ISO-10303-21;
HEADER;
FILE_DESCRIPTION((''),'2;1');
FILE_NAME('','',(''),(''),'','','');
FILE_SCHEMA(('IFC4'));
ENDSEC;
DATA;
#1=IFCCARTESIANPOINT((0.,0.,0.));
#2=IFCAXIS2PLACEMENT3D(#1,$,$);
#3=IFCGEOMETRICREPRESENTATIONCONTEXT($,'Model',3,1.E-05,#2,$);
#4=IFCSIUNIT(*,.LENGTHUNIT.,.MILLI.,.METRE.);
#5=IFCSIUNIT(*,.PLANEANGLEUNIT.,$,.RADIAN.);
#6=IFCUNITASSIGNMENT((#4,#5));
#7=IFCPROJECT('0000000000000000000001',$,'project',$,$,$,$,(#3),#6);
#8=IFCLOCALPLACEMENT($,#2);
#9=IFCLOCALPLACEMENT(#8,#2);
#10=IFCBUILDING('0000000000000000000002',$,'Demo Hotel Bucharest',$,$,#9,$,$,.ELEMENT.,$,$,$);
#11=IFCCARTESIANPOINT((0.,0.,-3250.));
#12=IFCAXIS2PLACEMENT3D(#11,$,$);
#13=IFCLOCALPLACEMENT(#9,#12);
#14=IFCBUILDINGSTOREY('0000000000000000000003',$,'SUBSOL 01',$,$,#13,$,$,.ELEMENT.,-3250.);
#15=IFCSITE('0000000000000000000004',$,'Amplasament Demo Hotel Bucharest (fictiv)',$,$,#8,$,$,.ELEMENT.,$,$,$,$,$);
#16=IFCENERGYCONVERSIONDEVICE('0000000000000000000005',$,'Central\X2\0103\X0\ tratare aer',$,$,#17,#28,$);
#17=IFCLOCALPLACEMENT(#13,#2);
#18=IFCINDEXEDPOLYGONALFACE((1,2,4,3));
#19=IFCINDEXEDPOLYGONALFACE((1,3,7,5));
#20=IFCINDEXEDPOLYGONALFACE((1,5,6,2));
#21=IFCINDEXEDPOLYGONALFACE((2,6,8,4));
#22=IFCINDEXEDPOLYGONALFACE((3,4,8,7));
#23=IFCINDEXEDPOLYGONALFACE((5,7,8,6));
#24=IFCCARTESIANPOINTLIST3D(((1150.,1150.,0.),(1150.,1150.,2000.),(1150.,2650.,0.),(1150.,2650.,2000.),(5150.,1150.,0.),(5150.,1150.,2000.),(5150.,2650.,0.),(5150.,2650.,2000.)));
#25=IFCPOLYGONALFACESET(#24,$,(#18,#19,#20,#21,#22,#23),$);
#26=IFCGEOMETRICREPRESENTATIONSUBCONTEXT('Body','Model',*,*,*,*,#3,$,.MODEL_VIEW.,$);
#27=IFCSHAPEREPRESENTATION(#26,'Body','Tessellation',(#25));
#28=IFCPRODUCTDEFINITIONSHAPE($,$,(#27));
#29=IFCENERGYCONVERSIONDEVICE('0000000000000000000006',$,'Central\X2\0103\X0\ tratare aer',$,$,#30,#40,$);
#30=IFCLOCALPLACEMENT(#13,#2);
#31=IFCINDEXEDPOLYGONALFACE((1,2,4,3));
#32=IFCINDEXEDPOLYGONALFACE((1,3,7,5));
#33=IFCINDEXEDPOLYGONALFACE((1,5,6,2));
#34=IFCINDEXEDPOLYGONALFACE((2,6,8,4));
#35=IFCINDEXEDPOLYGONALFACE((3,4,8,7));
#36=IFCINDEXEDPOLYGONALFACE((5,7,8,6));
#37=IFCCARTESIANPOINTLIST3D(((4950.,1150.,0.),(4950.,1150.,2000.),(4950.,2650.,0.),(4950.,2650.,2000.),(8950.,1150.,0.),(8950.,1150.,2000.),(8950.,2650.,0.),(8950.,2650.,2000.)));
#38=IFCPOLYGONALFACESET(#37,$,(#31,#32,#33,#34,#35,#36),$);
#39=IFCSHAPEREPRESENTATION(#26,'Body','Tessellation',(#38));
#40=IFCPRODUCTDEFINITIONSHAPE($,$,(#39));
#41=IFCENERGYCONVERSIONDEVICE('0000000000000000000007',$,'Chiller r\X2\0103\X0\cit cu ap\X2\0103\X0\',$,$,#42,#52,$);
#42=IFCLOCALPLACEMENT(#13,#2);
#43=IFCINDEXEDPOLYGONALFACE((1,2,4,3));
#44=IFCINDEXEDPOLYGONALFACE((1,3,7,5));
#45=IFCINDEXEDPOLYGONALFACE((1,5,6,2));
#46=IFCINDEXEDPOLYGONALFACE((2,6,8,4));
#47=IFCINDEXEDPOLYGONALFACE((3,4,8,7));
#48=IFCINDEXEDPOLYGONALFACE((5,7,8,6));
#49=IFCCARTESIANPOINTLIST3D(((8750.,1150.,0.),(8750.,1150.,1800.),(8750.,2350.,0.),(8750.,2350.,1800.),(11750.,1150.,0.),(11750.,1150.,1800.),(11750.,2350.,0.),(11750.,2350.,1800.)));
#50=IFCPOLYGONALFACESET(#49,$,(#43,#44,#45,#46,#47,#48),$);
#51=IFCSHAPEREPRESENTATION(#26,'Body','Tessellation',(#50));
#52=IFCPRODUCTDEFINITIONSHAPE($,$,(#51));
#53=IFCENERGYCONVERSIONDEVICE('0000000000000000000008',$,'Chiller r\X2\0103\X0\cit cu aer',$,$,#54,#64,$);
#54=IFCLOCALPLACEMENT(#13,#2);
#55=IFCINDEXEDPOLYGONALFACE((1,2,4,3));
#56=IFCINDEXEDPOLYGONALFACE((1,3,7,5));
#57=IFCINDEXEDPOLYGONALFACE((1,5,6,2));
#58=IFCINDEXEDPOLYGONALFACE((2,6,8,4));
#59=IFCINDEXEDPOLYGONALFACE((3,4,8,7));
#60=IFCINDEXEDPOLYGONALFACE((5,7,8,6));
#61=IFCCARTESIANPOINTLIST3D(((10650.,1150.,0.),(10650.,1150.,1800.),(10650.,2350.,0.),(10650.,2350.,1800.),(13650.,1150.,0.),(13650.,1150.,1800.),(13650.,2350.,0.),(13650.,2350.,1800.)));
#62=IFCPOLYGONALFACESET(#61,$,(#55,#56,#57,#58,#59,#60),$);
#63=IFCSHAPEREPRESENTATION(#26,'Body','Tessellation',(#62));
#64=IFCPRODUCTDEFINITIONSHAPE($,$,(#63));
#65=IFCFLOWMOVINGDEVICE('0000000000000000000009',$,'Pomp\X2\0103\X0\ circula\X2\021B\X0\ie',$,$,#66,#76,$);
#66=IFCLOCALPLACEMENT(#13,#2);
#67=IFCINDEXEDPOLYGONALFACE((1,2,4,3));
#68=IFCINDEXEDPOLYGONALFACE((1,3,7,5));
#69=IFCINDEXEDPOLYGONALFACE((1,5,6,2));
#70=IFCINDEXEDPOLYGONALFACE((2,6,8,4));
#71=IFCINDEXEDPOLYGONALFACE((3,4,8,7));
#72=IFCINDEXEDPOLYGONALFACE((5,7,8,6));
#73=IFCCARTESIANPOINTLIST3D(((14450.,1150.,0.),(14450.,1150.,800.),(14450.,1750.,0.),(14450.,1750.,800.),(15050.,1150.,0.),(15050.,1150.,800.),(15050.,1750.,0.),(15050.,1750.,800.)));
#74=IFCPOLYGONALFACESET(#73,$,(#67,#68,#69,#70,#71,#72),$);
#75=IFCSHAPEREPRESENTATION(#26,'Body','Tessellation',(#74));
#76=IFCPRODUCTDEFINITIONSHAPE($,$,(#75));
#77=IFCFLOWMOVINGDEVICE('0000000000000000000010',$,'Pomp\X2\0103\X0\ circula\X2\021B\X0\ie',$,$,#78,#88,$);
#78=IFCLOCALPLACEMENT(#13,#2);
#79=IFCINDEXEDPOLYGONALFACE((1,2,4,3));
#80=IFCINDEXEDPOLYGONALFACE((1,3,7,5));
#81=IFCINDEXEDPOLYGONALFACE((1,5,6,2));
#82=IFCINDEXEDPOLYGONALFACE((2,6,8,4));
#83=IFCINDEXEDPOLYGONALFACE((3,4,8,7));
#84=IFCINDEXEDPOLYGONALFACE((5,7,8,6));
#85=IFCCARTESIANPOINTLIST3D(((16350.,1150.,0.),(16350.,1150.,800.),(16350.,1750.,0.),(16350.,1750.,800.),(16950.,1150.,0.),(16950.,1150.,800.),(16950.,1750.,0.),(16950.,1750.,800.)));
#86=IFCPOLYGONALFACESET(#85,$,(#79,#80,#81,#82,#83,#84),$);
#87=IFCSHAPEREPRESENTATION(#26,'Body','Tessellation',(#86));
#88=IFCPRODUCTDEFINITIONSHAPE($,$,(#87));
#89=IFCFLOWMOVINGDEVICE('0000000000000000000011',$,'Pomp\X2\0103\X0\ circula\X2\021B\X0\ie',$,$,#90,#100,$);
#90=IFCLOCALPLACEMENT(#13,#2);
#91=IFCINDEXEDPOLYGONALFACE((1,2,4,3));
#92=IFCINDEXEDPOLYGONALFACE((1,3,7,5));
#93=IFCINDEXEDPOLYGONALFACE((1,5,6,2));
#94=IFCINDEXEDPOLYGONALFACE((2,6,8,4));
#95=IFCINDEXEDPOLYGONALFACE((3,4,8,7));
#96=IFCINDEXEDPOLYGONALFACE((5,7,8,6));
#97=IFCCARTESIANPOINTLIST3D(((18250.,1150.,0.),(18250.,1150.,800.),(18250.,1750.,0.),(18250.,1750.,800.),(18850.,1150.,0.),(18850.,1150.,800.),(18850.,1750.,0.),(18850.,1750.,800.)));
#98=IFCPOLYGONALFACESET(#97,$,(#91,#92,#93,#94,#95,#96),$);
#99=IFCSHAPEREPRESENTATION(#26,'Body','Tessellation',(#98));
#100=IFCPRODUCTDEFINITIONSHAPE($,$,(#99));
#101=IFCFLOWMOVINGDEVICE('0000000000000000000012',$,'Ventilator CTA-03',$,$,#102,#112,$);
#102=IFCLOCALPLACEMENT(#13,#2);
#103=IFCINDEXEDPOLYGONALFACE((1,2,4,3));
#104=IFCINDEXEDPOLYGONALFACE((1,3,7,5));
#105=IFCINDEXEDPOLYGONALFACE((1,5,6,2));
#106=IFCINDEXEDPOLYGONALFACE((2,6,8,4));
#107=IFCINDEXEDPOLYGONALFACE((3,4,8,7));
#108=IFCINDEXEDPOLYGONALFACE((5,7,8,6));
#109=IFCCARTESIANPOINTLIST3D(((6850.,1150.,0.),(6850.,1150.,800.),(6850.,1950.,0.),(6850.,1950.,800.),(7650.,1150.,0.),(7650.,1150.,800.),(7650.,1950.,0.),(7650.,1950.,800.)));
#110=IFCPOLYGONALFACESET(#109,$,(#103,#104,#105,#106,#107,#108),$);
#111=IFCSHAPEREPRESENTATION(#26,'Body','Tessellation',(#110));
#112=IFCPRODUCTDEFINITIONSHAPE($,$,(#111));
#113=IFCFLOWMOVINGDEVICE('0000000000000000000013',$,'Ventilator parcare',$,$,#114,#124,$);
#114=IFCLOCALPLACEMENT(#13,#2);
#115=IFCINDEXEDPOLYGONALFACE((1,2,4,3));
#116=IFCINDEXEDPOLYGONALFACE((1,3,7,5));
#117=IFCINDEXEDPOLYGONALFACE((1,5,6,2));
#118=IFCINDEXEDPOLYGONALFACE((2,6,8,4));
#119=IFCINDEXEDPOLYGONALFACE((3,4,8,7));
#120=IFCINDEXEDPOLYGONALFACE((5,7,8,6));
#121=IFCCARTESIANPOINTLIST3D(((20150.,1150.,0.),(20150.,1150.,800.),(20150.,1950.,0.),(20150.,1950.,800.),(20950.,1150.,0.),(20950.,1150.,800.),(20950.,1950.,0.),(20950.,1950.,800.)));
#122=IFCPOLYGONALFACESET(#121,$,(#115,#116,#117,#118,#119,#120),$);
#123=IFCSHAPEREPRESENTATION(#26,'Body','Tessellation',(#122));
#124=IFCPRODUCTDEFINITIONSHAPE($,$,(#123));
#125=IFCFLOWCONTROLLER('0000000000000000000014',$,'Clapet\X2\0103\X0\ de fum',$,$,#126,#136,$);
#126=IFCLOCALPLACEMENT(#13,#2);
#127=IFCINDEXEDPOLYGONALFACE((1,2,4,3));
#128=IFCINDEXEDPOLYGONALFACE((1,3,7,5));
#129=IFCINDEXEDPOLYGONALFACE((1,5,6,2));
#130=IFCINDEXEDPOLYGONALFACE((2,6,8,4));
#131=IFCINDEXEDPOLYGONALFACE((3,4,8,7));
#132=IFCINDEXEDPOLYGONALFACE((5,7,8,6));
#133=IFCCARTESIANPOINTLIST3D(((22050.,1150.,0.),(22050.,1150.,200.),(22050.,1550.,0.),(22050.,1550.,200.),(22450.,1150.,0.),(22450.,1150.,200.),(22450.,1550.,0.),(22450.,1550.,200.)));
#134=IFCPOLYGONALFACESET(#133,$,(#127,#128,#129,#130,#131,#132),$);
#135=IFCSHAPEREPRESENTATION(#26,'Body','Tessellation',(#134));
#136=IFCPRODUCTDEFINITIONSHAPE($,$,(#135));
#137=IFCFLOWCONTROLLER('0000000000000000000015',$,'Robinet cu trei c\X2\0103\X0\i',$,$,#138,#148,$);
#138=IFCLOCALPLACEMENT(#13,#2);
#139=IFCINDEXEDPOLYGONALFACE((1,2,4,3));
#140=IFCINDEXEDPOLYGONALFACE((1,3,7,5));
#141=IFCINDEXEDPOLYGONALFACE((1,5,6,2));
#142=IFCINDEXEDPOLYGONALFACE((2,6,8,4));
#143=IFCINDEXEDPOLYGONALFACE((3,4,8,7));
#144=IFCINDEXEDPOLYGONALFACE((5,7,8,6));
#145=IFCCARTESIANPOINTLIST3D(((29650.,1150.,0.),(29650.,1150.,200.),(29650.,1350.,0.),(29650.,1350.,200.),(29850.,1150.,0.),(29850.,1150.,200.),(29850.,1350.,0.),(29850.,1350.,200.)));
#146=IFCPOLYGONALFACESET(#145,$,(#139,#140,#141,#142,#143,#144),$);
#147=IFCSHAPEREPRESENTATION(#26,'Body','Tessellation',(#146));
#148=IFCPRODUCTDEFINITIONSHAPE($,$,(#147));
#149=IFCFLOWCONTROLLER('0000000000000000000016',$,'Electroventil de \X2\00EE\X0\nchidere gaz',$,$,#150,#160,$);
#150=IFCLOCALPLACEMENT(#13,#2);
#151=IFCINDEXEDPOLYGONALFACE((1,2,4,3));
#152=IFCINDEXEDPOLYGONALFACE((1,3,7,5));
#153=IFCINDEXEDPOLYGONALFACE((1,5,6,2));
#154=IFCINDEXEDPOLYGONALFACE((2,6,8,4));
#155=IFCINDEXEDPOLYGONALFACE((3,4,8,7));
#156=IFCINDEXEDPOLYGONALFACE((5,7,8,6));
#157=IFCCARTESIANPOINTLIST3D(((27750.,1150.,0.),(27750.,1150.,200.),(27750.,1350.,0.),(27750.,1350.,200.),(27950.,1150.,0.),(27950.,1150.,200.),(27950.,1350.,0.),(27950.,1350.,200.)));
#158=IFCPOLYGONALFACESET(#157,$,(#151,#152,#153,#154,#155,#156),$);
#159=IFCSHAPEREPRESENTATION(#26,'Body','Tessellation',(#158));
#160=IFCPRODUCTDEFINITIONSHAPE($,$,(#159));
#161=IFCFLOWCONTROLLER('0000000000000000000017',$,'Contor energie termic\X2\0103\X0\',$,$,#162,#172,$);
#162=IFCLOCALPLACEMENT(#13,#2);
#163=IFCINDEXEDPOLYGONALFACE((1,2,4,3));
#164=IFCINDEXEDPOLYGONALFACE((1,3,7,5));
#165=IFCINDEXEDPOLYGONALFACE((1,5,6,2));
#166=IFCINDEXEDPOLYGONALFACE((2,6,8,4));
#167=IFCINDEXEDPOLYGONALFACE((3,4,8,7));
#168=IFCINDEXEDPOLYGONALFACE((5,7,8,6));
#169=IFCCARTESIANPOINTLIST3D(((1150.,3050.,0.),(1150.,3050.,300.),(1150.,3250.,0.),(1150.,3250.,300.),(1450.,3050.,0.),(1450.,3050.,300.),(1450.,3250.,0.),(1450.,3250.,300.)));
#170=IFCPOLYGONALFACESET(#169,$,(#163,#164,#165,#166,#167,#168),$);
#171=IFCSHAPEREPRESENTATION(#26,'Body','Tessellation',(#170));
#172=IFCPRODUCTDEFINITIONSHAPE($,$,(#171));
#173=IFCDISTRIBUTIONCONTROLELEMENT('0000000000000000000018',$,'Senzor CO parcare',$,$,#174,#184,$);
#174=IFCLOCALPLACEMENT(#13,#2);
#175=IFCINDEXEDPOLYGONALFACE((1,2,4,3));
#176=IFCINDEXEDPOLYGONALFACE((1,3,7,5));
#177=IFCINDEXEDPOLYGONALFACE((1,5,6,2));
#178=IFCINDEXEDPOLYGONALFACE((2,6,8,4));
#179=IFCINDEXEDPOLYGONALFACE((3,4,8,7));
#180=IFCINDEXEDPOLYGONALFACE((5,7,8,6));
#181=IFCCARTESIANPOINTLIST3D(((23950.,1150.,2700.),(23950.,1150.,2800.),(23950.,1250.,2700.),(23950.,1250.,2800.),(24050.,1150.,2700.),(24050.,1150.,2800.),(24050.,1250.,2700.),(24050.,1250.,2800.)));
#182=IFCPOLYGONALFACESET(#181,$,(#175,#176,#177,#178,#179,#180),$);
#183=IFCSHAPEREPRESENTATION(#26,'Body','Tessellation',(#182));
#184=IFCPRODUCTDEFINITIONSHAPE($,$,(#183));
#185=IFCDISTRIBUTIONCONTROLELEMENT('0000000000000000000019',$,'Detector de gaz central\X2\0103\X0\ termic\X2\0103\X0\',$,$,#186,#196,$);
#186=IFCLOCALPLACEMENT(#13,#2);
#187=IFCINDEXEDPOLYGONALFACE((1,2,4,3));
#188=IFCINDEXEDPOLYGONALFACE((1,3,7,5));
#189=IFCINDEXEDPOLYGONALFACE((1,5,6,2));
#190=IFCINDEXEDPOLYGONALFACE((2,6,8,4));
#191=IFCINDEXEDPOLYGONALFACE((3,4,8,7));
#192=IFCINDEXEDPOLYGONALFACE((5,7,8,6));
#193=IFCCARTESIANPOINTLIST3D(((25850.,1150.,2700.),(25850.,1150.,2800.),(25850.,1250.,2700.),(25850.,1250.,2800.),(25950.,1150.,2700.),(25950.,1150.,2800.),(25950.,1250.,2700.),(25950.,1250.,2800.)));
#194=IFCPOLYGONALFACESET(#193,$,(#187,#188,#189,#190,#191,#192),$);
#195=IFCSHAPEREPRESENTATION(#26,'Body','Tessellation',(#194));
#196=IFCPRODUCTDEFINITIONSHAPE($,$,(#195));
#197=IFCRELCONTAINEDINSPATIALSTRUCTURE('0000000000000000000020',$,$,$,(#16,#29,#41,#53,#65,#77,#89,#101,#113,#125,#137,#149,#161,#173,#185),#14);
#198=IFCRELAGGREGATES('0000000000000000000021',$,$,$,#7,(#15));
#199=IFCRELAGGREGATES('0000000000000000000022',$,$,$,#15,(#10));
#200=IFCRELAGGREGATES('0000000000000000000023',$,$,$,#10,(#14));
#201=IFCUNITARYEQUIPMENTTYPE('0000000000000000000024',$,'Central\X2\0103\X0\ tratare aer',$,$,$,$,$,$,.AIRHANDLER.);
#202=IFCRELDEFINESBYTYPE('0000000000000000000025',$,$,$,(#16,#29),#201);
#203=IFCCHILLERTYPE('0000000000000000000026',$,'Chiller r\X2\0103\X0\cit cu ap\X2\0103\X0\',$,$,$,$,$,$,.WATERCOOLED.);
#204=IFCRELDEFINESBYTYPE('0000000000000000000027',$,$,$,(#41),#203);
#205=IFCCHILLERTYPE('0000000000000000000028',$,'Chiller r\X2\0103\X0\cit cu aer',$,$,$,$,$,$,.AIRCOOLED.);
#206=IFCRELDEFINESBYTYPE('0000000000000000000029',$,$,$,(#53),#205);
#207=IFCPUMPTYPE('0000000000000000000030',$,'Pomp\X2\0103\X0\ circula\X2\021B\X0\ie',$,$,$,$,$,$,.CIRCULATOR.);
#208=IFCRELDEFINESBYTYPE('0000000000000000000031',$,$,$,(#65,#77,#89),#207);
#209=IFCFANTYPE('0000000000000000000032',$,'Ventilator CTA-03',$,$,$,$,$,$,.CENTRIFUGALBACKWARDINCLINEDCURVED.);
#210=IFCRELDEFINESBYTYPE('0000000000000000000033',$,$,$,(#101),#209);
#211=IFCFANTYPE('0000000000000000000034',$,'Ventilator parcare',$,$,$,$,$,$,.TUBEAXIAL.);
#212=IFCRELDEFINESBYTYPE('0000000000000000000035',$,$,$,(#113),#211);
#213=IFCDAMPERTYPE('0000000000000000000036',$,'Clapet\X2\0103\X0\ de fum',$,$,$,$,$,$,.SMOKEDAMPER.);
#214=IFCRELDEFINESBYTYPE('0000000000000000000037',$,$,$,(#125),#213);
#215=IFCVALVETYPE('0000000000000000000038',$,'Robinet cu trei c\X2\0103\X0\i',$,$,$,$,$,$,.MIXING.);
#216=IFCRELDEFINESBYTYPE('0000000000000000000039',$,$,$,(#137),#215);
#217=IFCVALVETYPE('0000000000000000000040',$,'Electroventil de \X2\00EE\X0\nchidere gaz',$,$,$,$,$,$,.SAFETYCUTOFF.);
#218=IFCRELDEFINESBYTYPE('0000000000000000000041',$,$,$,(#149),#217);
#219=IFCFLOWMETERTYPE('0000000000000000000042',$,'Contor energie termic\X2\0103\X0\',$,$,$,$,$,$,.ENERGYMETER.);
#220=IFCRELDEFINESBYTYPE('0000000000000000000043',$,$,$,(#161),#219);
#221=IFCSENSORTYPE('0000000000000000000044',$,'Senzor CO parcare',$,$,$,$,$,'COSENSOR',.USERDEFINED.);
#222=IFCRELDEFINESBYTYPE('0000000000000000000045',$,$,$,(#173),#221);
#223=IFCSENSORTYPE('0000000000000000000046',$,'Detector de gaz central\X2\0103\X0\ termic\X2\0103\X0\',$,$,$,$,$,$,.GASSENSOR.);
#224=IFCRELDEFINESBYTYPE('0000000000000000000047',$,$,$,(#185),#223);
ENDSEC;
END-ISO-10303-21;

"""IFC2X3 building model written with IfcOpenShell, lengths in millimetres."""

from ifc_helpers import new_model, si_unit, frame, frame_2d, origin, place, context, subcontext, project, spatial, rectangle, extrude, type_object, element, save


model = new_model("IFC2X3")

# Units and contexts
model_context = context("Model", 3, precision=1e-05, world=origin())
body_context = subcontext(model_context, "Body", "Model", "MODEL_VIEW")
ifc_project = project(units=[si_unit("LENGTHUNIT", "METRE", prefix="MILLI"), si_unit("PLANEANGLEUNIT", "RADIAN")], contexts=[model_context])

# Site, building, storey
site_placement = place(None, origin())
site = spatial("IfcSite", under=ifc_project, at=site_placement, Name="Amplasament Demo Hotel Bucharest (fictiv)", CompositionType="ELEMENT")
building_placement = place(site_placement, origin())
building = spatial("IfcBuilding", under=site, at=building_placement, Name="Demo Hotel Bucharest", CompositionType="ELEMENT")
storey_placement = place(building_placement, frame((0.0, 0.0, -3250.0)))
storey = spatial("IfcBuildingStorey", under=building, at=storey_placement, Name="SUBSOL 01", CompositionType="ELEMENT", Elevation=-3250.0)

# Energy conversion devices
unitary_equipment_type = type_object("IfcUnitaryEquipmentType", Name="Centrală tratare aer", PredefinedType="AIRHANDLER")
for number, where, name in (
    (1, (1150.0, 1150.0, 0.0), "Centrală tratare aer"),
    (2, (4950.0, 1150.0, 0.0), "Centrală tratare aer"),
):
    element("IfcEnergyConversionDevice", number, at=place(storey_placement, frame(where)), inside=storey, type_object=unitary_equipment_type, Name=name, context=body_context, shape_type="SweptSolid", body=[
        extrude(rectangle(XDim=4000.0, YDim=1500.0, at=frame_2d((2000.0, 750.0))), origin(), (0.0, 0.0, 1.0), 2000.0),
    ])
chiller_type_1 = type_object("IfcChillerType", Name="Chiller răcit cu apă", PredefinedType="WATERCOOLED")
energy_conversion_device_1_placement = place(storey_placement, frame((8750.0, 1150.0, 0.0)))
element("IfcEnergyConversionDevice", 3, at=energy_conversion_device_1_placement, inside=storey, type_object=chiller_type_1, Name="Chiller răcit cu apă", context=body_context, shape_type="SweptSolid", body=[
    extrude(rectangle(XDim=3000.0, YDim=1200.0, at=frame_2d((1500.0, 600.0))), origin(), (0.0, 0.0, 1.0), 1800.0),
])
chiller_type_2 = type_object("IfcChillerType", Name="Chiller răcit cu aer", PredefinedType="AIRCOOLED")
energy_conversion_device_2_placement = place(storey_placement, frame((10650.0, 1150.0, 0.0)))
element("IfcEnergyConversionDevice", 4, at=energy_conversion_device_2_placement, inside=storey, type_object=chiller_type_2, Name="Chiller răcit cu aer", context=body_context, shape_type="SweptSolid", body=[
    extrude(rectangle(XDim=3000.0, YDim=1200.0, at=frame_2d((1500.0, 600.0))), origin(), (0.0, 0.0, 1.0), 1800.0),
])

# Flow moving devices
pump_type = type_object("IfcPumpType", Name="Pompă circulație", PredefinedType="CIRCULATOR")
for number, where, name in (
    (5, (14450.0, 1150.0, 0.0), "Pompă circulație"),
    (6, (16350.0, 1150.0, 0.0), "Pompă circulație"),
    (7, (18250.0, 1150.0, 0.0), "Pompă circulație"),
):
    element("IfcFlowMovingDevice", number, at=place(storey_placement, frame(where)), inside=storey, type_object=pump_type, Name=name, context=body_context, shape_type="SweptSolid", body=[
        extrude(rectangle(XDim=600.0, YDim=600.0, at=frame_2d((300.0, 300.0))), origin(), (0.0, 0.0, 1.0), 800.0),
    ])
fan_type_1 = type_object("IfcFanType", Name="Ventilator CTA-03", PredefinedType="CENTRIFUGALBACKWARDINCLINEDCURVED")
flow_moving_device_1_placement = place(storey_placement, frame((6850.0, 1150.0, 0.0)))
element("IfcFlowMovingDevice", 8, at=flow_moving_device_1_placement, inside=storey, type_object=fan_type_1, Name="Ventilator CTA-03", context=body_context, shape_type="SweptSolid", body=[
    extrude(rectangle(XDim=800.0, YDim=800.0, at=frame_2d((400.0, 400.0))), origin(), (0.0, 0.0, 1.0), 800.0),
])
fan_type_2 = type_object("IfcFanType", Name="Ventilator parcare", PredefinedType="TUBEAXIAL")
flow_moving_device_2_placement = place(storey_placement, frame((20150.0, 1150.0, 0.0)))
element("IfcFlowMovingDevice", 9, at=flow_moving_device_2_placement, inside=storey, type_object=fan_type_2, Name="Ventilator parcare", context=body_context, shape_type="SweptSolid", body=[
    extrude(rectangle(XDim=800.0, YDim=800.0, at=frame_2d((400.0, 400.0))), origin(), (0.0, 0.0, 1.0), 800.0),
])

# Flow controllers
damper_type = type_object("IfcDamperType", Name="Clapetă de fum", PredefinedType="SMOKEDAMPER")
flow_controller_1_placement = place(storey_placement, frame((22050.0, 1150.0, 0.0)))
element("IfcFlowController", 10, at=flow_controller_1_placement, inside=storey, type_object=damper_type, Name="Clapetă de fum", context=body_context, shape_type="SweptSolid", body=[
    extrude(rectangle(XDim=400.0, YDim=400.0, at=frame_2d((200.0, 200.0))), origin(), (0.0, 0.0, 1.0), 200.0),
])
valve_type_1 = type_object("IfcValveType", Name="Robinet cu trei căi", PredefinedType="MIXING")
flow_controller_2_placement = place(storey_placement, frame((29650.0, 1150.0, 0.0)))
element("IfcFlowController", 11, at=flow_controller_2_placement, inside=storey, type_object=valve_type_1, Name="Robinet cu trei căi", context=body_context, shape_type="SweptSolid", body=[
    extrude(rectangle(XDim=200.0, YDim=200.0, at=frame_2d((100.0, 100.0))), origin(), (0.0, 0.0, 1.0), 200.0),
])
valve_type_2 = type_object("IfcValveType", Name="Electroventil de închidere gaz", PredefinedType="SAFETYCUTOFF")
flow_controller_3_placement = place(storey_placement, frame((27750.0, 1150.0, 0.0)))
element("IfcFlowController", 12, at=flow_controller_3_placement, inside=storey, type_object=valve_type_2, Name="Electroventil de închidere gaz", context=body_context, shape_type="SweptSolid", body=[
    extrude(rectangle(XDim=200.0, YDim=200.0, at=frame_2d((100.0, 100.0))), origin(), (0.0, 0.0, 1.0), 200.0),
])
flow_meter_type = type_object("IfcFlowMeterType", Name="Contor energie termică", PredefinedType="ENERGYMETER")
flow_controller_4_placement = place(storey_placement, frame((1150.0, 3050.0, 0.0)))
element("IfcFlowController", 13, at=flow_controller_4_placement, inside=storey, type_object=flow_meter_type, Name="Contor energie termică", context=body_context, shape_type="SweptSolid", body=[
    extrude(rectangle(XDim=300.0, YDim=200.0, at=frame_2d((150.0, 100.0))), origin(), (0.0, 0.0, 1.0), 300.0),
])

# Distribution control elements
sensor_type_1 = type_object("IfcSensorType", Name="Senzor CO parcare", ElementType="COSENSOR", PredefinedType="USERDEFINED")
distribution_control_element_1_placement = place(storey_placement, frame((23950.0, 1150.0, 2700.0)))
element("IfcDistributionControlElement", 14, at=distribution_control_element_1_placement, inside=storey, type_object=sensor_type_1, Name="Senzor CO parcare", context=body_context, shape_type="SweptSolid", body=[
    extrude(rectangle(XDim=100.0, YDim=100.0, at=frame_2d((50.0, 50.0))), origin(), (0.0, 0.0, 1.0), 100.0),
])
sensor_type_2 = type_object("IfcSensorType", Name="Detector de gaz centrală termică", PredefinedType="GASSENSOR")
distribution_control_element_2_placement = place(storey_placement, frame((25850.0, 1150.0, 2700.0)))
element("IfcDistributionControlElement", 15, at=distribution_control_element_2_placement, inside=storey, type_object=sensor_type_2, Name="Detector de gaz centrală termică", context=body_context, shape_type="SweptSolid", body=[
    extrude(rectangle(XDim=100.0, YDim=100.0, at=frame_2d((50.0, 50.0))), origin(), (0.0, 0.0, 1.0), 100.0),
])

save(model, "model.ifc")
